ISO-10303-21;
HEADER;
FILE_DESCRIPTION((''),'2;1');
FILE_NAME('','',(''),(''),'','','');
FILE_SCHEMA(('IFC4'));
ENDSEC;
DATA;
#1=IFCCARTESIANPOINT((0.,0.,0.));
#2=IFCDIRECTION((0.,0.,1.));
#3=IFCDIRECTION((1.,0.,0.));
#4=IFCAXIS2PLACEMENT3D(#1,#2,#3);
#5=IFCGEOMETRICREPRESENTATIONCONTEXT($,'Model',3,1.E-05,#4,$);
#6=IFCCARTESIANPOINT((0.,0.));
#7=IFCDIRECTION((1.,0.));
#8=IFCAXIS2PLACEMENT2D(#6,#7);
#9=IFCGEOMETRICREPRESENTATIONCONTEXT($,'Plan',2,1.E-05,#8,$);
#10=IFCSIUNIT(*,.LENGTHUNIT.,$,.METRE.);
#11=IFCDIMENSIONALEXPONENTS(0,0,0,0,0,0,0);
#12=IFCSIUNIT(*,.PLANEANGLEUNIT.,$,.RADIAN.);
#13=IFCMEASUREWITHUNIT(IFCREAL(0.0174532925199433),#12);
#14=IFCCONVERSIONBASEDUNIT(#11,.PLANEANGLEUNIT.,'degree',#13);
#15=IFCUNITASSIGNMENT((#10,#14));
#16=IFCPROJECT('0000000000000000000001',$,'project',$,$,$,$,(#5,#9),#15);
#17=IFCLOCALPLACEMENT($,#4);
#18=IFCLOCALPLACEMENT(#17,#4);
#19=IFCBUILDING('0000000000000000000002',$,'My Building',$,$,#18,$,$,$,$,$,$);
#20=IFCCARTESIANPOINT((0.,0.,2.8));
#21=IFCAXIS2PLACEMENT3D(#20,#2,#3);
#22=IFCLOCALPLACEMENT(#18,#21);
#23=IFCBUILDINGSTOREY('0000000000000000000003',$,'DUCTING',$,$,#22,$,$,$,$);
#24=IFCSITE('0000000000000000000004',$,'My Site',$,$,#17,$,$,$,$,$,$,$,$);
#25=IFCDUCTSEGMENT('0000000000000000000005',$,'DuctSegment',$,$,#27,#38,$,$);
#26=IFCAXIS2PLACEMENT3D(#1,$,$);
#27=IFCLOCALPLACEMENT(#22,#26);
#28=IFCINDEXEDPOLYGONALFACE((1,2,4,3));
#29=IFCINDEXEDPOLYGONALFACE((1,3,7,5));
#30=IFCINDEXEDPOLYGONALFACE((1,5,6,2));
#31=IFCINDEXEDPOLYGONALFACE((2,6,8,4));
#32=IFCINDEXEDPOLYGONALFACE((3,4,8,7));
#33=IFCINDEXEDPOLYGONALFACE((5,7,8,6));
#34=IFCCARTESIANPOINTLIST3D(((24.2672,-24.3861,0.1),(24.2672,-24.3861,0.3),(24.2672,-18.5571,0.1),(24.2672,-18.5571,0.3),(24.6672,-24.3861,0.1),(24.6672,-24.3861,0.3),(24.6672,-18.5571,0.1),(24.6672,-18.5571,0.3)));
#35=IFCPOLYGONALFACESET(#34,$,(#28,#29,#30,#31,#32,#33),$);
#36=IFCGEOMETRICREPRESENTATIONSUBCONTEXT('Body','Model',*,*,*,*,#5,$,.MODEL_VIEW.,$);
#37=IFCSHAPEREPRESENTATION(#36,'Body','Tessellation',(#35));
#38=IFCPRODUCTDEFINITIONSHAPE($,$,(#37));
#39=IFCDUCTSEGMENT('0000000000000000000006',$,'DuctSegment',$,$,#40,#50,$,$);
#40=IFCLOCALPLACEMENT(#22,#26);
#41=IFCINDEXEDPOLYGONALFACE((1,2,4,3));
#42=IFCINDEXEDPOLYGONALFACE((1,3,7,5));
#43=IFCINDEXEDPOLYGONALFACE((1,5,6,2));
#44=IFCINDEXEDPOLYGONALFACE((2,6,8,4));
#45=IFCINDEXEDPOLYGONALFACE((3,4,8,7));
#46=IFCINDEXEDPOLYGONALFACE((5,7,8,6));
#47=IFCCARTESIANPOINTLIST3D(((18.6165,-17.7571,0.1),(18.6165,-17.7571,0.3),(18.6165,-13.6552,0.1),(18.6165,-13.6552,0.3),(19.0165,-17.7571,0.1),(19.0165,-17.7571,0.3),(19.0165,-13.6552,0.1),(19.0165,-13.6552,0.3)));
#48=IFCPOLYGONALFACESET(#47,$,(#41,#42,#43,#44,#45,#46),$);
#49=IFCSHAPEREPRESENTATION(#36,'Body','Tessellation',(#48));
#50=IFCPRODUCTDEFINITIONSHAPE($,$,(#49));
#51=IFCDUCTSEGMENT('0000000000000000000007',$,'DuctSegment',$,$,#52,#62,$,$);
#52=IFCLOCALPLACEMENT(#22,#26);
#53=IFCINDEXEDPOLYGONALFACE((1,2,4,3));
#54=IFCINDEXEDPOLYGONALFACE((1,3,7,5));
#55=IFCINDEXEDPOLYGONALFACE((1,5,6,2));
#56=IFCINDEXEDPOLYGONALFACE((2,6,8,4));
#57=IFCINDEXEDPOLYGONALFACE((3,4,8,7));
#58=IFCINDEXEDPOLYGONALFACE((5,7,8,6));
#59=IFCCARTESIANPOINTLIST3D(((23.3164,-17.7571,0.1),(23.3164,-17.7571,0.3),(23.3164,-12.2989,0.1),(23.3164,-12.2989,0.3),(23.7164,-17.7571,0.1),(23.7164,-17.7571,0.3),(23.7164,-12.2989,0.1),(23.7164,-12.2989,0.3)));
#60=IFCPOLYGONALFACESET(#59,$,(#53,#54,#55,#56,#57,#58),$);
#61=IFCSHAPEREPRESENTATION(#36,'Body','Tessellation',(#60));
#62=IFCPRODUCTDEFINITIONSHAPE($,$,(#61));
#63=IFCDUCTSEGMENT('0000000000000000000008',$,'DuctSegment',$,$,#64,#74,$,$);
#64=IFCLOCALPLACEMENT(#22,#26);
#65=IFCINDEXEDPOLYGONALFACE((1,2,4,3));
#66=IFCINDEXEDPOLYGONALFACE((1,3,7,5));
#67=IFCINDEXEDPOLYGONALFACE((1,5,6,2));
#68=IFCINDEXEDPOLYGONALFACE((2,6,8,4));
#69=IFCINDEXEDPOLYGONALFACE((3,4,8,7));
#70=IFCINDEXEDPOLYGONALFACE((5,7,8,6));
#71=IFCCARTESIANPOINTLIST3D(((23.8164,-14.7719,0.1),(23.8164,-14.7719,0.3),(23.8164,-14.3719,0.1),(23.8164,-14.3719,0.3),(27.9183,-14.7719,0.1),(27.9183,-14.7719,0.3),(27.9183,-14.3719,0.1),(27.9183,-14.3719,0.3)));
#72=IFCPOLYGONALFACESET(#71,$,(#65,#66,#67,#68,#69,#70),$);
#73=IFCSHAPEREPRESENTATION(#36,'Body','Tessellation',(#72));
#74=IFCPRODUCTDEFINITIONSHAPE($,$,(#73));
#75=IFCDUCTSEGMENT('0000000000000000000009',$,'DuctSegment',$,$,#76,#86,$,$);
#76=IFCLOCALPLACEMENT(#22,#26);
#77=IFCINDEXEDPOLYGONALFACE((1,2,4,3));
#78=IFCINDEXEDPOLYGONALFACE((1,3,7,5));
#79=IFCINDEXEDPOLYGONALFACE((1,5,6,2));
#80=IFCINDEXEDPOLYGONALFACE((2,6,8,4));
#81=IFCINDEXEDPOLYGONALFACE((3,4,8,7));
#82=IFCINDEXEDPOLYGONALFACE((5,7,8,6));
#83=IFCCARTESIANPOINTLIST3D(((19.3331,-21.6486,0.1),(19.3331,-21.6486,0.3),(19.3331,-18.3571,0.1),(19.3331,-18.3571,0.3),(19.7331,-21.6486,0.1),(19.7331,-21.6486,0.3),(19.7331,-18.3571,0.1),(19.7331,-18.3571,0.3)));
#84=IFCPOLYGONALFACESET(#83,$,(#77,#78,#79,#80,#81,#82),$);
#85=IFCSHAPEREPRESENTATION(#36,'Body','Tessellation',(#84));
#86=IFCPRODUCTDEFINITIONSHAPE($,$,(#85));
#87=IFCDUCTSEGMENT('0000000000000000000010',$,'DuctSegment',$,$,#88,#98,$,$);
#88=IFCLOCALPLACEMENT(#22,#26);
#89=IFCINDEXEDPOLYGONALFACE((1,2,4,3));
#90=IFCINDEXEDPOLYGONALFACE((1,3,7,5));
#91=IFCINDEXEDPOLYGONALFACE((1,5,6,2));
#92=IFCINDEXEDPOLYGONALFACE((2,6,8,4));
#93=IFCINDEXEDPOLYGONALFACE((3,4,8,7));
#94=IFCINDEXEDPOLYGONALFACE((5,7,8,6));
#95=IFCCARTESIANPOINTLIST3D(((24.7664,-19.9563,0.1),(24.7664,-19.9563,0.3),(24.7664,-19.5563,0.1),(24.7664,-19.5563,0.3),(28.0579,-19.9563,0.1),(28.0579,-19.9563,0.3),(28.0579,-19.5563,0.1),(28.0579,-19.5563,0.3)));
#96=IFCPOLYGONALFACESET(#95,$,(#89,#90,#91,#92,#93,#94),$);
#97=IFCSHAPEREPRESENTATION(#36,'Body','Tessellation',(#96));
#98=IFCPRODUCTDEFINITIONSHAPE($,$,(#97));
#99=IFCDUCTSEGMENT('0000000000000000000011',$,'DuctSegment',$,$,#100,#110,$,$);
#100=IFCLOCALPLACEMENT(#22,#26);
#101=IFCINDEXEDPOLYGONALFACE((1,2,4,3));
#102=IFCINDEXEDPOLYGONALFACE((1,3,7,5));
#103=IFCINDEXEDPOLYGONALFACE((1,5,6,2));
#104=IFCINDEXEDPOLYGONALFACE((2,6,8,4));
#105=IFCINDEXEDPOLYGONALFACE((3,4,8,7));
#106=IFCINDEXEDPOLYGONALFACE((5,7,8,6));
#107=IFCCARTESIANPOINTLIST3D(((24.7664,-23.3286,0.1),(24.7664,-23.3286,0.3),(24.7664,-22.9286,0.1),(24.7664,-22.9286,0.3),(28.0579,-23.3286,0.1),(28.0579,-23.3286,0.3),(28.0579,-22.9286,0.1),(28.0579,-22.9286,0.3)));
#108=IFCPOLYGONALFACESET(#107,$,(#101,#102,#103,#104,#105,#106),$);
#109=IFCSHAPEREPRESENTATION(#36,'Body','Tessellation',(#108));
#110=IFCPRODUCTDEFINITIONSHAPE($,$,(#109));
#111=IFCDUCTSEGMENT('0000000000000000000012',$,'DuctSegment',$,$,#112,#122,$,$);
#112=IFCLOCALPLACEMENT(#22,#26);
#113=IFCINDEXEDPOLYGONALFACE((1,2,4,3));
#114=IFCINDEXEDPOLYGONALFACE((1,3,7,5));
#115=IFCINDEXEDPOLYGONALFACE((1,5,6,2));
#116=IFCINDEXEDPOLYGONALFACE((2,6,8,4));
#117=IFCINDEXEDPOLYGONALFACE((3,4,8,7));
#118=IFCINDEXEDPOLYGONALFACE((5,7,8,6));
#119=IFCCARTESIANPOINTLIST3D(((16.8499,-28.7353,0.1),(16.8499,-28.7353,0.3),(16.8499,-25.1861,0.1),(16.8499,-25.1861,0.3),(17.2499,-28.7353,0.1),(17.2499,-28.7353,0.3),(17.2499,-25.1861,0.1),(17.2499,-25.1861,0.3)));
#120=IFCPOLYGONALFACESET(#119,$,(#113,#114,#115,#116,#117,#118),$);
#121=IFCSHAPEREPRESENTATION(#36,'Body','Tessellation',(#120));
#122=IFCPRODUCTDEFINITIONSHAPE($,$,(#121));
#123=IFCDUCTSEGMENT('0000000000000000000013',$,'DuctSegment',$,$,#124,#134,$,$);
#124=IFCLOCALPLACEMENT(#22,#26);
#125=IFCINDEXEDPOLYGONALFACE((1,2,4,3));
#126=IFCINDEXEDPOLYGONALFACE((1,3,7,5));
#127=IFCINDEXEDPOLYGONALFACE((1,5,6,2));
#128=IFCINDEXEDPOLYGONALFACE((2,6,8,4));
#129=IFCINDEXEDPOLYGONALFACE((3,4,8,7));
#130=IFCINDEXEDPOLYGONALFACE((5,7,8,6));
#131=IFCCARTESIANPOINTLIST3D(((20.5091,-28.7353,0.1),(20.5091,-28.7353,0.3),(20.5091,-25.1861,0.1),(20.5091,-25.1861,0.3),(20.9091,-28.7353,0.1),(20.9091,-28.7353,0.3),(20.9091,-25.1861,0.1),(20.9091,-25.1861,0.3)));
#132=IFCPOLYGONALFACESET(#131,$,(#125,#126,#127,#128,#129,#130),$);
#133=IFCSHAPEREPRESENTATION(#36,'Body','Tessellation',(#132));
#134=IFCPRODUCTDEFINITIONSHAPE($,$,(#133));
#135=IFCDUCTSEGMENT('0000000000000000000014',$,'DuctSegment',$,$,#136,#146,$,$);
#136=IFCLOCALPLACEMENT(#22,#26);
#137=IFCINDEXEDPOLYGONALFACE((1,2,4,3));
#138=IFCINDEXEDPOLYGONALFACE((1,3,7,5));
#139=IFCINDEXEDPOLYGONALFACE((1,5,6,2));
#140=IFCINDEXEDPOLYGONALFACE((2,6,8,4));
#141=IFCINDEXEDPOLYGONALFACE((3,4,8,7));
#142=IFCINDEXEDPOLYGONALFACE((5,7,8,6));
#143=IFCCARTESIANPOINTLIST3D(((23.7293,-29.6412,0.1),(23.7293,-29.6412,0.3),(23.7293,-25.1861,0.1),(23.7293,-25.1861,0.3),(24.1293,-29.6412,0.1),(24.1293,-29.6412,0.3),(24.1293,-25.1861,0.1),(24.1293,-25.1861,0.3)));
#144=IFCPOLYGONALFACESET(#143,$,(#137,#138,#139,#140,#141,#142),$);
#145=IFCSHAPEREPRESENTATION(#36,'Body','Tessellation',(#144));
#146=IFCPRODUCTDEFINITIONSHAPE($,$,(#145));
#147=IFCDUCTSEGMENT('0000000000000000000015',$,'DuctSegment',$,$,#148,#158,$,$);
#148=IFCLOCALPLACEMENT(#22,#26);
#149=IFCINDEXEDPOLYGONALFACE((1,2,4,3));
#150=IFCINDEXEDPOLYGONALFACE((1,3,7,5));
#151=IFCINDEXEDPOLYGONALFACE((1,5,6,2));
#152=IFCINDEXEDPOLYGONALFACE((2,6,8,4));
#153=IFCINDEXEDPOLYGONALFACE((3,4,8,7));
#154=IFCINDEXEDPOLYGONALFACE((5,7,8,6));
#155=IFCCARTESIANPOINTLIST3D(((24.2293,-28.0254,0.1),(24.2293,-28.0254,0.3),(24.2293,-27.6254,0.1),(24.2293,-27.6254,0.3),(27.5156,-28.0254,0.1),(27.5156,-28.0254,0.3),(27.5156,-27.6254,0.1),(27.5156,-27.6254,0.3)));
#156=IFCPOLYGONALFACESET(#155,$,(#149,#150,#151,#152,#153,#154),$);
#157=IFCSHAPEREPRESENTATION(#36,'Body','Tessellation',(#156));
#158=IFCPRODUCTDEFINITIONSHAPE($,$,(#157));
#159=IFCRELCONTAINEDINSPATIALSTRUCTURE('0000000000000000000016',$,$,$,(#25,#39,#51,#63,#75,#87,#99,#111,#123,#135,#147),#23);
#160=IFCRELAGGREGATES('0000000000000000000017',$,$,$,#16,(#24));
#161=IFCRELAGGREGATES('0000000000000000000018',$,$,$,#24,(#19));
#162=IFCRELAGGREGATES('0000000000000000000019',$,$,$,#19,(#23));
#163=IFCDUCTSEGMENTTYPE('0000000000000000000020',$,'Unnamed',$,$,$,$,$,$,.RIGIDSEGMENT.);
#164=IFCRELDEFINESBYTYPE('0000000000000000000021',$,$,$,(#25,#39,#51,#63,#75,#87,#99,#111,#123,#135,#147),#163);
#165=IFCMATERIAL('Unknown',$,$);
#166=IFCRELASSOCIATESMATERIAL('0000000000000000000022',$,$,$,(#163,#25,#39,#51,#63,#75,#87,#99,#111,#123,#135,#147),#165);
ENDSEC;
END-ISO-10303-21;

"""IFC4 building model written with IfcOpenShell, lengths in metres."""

from ifc_helpers import new_model, entity, si_unit, converted_unit, frame, origin_with_axes, origin_2d_with_axis, place, context, subcontext, project, spatial, rectangle, extrude, material, material_profile, profile_set, profile_usage, type_object, element, save


model = new_model("IFC4")

# Units and contexts
model_context = context("Model", 3, precision=1e-05, world=origin_with_axes())
plan_context = context("Plan", 2, precision=1e-05, world=origin_2d_with_axis())
body_context = subcontext(model_context, "Body", "Model", "MODEL_VIEW")
ifc_project = project(units=[si_unit("LENGTHUNIT", "METRE"), converted_unit("PLANEANGLEUNIT", "degree", entity("IfcReal", 0.0174532925199433), si_unit("PLANEANGLEUNIT", "RADIAN"), dimensions=[0, 0, 0, 0, 0, 0, 0])], contexts=[model_context, plan_context])

# Site, building, storey
site_placement = place(None, origin_with_axes())
site = spatial("IfcSite", under=ifc_project, at=site_placement, Name="My Site")
building_placement = place(site_placement, origin_with_axes())
building = spatial("IfcBuilding", under=site, at=building_placement, Name="My Building")
storey_placement = place(building_placement, frame((0.0, 0.0, 2.8), z_axis=(0.0, 0.0, 1.0), x_axis=(1.0, 0.0, 0.0)))
storey = spatial("IfcBuildingStorey", under=building, at=storey_placement, Name="DUCTING")

# Duct segments
ifc_material = material(Name="Unknown")
ifc_material_profile_1 = material_profile(ifc_material, rectangle(XDim=0.4, YDim=0.2))
ifc_profile_set_1 = profile_set([ifc_material_profile_1])
ifc_profile_usage_1 = profile_usage(ifc_profile_set_1, cardinal=5)
duct_segment_type = type_object("IfcDuctSegmentType", Name="Unnamed", PredefinedType="RIGIDSEGMENT", material=ifc_profile_set_1)
duct_segment_1_placement = place(storey_placement, frame((24.4672, -18.5571, 0.2), z_axis=(0.0, -1.0, 0.0), x_axis=(1.0, 0.0, 0.0)))
element("IfcDuctSegment", 1, at=duct_segment_1_placement, inside=storey, type_object=duct_segment_type, material=ifc_profile_usage_1, Name="DuctSegment", context=body_context, shape_type="SweptSolid", body=[
    extrude(rectangle(XDim=0.4, YDim=0.2), origin_with_axes(), (0.0, 0.0, 1.0), 5.8291),
])
ifc_profile_usage_2 = profile_usage(ifc_profile_set_1, cardinal=5)
duct_segment_2_placement = place(storey_placement, frame((18.8165, -17.7571, 0.2), z_axis=(0.0, 1.0, 0.0), x_axis=(-1.0, 0.0, 0.0)))
element("IfcDuctSegment", 2, at=duct_segment_2_placement, inside=storey, type_object=duct_segment_type, material=ifc_profile_usage_2, Name="DuctSegment", context=body_context, shape_type="SweptSolid", body=[
    extrude(rectangle(XDim=0.4, YDim=0.2), origin_with_axes(), (0.0, 0.0, 1.0), 4.1019),
])
ifc_profile_usage_3 = profile_usage(ifc_profile_set_1, cardinal=5)
duct_segment_3_placement = place(storey_placement, frame((23.5164, -17.7571, 0.2), z_axis=(0.0, 1.0, 0.0), x_axis=(-1.0, 0.0, 0.0)))
element("IfcDuctSegment", 3, at=duct_segment_3_placement, inside=storey, type_object=duct_segment_type, material=ifc_profile_usage_3, Name="DuctSegment", context=body_context, shape_type="SweptSolid", body=[
    extrude(rectangle(XDim=0.4, YDim=0.2), origin_with_axes(), (0.0, 0.0, 1.0), 5.4582),
])
ifc_profile_usage_4 = profile_usage(ifc_profile_set_1, cardinal=5)
duct_segment_4_placement = place(storey_placement, frame((23.8164, -14.5719, 0.2), z_axis=(1.0, 0.0, 0.0), x_axis=(0.0, 1.0, 0.0)))
element("IfcDuctSegment", 4, at=duct_segment_4_placement, inside=storey, type_object=duct_segment_type, material=ifc_profile_usage_4, Name="DuctSegment", context=body_context, shape_type="SweptSolid", body=[
    extrude(rectangle(XDim=0.4, YDim=0.2), origin_with_axes(), (0.0, 0.0, 1.0), 4.1019),
])
ifc_profile_usage_5 = profile_usage(ifc_profile_set_1, cardinal=5)
duct_segment_5_placement = place(storey_placement, frame((19.5331, -18.3571, 0.2), z_axis=(0.0, -1.0, 0.0), x_axis=(1.0, 0.0, 0.0)))
element("IfcDuctSegment", 5, at=duct_segment_5_placement, inside=storey, type_object=duct_segment_type, material=ifc_profile_usage_5, Name="DuctSegment", context=body_context, shape_type="SweptSolid", body=[
    extrude(rectangle(XDim=0.4, YDim=0.2), origin_with_axes(), (0.0, 0.0, 1.0), 3.2916),
])
ifc_profile_usage_6 = profile_usage(ifc_profile_set_1, cardinal=5)
duct_segment_6_placement = place(storey_placement, frame((24.7664, -19.7563, 0.2), z_axis=(1.0, 0.0, 0.0), x_axis=(0.0, 1.0, 0.0)))
element("IfcDuctSegment", 6, at=duct_segment_6_placement, inside=storey, type_object=duct_segment_type, material=ifc_profile_usage_6, Name="DuctSegment", context=body_context, shape_type="SweptSolid", body=[
    extrude(rectangle(XDim=0.4, YDim=0.2), origin_with_axes(), (0.0, 0.0, 1.0), 3.2916),
])
ifc_profile_usage_7 = profile_usage(ifc_profile_set_1, cardinal=5)
duct_segment_7_placement = place(storey_placement, frame((24.7664, -23.1286, 0.2), z_axis=(1.0, 0.0, 0.0), x_axis=(0.0, 1.0, 0.0)))
element("IfcDuctSegment", 7, at=duct_segment_7_placement, inside=storey, type_object=duct_segment_type, material=ifc_profile_usage_7, Name="DuctSegment", context=body_context, shape_type="SweptSolid", body=[
    extrude(rectangle(XDim=0.4, YDim=0.2), origin_with_axes(), (0.0, 0.0, 1.0), 3.2916),
])
ifc_profile_usage_8 = profile_usage(ifc_profile_set_1, cardinal=5)
duct_segment_8_placement = place(storey_placement, frame((17.0499, -25.1861, 0.2), z_axis=(0.0, -1.0, 0.0), x_axis=(1.0, 0.0, 0.0)))
element("IfcDuctSegment", 8, at=duct_segment_8_placement, inside=storey, type_object=duct_segment_type, material=ifc_profile_usage_8, Name="DuctSegment", context=body_context, shape_type="SweptSolid", body=[
    extrude(rectangle(XDim=0.4, YDim=0.2), origin_with_axes(), (0.0, 0.0, 1.0), 3.5492),
])
ifc_profile_usage_9 = profile_usage(ifc_profile_set_1, cardinal=5)
duct_segment_9_placement = place(storey_placement, frame((20.7091, -25.1861, 0.2), z_axis=(0.0, -1.0, 0.0), x_axis=(1.0, 0.0, 0.0)))
element("IfcDuctSegment", 9, at=duct_segment_9_placement, inside=storey, type_object=duct_segment_type, material=ifc_profile_usage_9, Name="DuctSegment", context=body_context, shape_type="SweptSolid", body=[
    extrude(rectangle(XDim=0.4, YDim=0.2), origin_with_axes(), (0.0, 0.0, 1.0), 3.5492),
])
ifc_profile_usage_10 = profile_usage(ifc_profile_set_1, cardinal=5)
duct_segment_10_placement = place(storey_placement, frame((23.9293, -25.1861, 0.2), z_axis=(0.0, -1.0, 0.0), x_axis=(1.0, 0.0, 0.0)))
element("IfcDuctSegment", 10, at=duct_segment_10_placement, inside=storey, type_object=duct_segment_type, material=ifc_profile_usage_10, Name="DuctSegment", context=body_context, shape_type="SweptSolid", body=[
    extrude(rectangle(XDim=0.4, YDim=0.2), origin_with_axes(), (0.0, 0.0, 1.0), 4.4551),
])
ifc_profile_usage_11 = profile_usage(ifc_profile_set_1, cardinal=5)
duct_segment_11_placement = place(storey_placement, frame((24.2293, -27.8254, 0.2), z_axis=(1.0, 0.0, 0.0), x_axis=(0.0, 1.0, 0.0)))
element("IfcDuctSegment", 11, at=duct_segment_11_placement, inside=storey, type_object=duct_segment_type, material=ifc_profile_usage_11, Name="DuctSegment", context=body_context, shape_type="SweptSolid", body=[
    extrude(rectangle(XDim=0.4, YDim=0.2), origin_with_axes(), (0.0, 0.0, 1.0), 3.2863),
])

save(model, "model.ifc")
